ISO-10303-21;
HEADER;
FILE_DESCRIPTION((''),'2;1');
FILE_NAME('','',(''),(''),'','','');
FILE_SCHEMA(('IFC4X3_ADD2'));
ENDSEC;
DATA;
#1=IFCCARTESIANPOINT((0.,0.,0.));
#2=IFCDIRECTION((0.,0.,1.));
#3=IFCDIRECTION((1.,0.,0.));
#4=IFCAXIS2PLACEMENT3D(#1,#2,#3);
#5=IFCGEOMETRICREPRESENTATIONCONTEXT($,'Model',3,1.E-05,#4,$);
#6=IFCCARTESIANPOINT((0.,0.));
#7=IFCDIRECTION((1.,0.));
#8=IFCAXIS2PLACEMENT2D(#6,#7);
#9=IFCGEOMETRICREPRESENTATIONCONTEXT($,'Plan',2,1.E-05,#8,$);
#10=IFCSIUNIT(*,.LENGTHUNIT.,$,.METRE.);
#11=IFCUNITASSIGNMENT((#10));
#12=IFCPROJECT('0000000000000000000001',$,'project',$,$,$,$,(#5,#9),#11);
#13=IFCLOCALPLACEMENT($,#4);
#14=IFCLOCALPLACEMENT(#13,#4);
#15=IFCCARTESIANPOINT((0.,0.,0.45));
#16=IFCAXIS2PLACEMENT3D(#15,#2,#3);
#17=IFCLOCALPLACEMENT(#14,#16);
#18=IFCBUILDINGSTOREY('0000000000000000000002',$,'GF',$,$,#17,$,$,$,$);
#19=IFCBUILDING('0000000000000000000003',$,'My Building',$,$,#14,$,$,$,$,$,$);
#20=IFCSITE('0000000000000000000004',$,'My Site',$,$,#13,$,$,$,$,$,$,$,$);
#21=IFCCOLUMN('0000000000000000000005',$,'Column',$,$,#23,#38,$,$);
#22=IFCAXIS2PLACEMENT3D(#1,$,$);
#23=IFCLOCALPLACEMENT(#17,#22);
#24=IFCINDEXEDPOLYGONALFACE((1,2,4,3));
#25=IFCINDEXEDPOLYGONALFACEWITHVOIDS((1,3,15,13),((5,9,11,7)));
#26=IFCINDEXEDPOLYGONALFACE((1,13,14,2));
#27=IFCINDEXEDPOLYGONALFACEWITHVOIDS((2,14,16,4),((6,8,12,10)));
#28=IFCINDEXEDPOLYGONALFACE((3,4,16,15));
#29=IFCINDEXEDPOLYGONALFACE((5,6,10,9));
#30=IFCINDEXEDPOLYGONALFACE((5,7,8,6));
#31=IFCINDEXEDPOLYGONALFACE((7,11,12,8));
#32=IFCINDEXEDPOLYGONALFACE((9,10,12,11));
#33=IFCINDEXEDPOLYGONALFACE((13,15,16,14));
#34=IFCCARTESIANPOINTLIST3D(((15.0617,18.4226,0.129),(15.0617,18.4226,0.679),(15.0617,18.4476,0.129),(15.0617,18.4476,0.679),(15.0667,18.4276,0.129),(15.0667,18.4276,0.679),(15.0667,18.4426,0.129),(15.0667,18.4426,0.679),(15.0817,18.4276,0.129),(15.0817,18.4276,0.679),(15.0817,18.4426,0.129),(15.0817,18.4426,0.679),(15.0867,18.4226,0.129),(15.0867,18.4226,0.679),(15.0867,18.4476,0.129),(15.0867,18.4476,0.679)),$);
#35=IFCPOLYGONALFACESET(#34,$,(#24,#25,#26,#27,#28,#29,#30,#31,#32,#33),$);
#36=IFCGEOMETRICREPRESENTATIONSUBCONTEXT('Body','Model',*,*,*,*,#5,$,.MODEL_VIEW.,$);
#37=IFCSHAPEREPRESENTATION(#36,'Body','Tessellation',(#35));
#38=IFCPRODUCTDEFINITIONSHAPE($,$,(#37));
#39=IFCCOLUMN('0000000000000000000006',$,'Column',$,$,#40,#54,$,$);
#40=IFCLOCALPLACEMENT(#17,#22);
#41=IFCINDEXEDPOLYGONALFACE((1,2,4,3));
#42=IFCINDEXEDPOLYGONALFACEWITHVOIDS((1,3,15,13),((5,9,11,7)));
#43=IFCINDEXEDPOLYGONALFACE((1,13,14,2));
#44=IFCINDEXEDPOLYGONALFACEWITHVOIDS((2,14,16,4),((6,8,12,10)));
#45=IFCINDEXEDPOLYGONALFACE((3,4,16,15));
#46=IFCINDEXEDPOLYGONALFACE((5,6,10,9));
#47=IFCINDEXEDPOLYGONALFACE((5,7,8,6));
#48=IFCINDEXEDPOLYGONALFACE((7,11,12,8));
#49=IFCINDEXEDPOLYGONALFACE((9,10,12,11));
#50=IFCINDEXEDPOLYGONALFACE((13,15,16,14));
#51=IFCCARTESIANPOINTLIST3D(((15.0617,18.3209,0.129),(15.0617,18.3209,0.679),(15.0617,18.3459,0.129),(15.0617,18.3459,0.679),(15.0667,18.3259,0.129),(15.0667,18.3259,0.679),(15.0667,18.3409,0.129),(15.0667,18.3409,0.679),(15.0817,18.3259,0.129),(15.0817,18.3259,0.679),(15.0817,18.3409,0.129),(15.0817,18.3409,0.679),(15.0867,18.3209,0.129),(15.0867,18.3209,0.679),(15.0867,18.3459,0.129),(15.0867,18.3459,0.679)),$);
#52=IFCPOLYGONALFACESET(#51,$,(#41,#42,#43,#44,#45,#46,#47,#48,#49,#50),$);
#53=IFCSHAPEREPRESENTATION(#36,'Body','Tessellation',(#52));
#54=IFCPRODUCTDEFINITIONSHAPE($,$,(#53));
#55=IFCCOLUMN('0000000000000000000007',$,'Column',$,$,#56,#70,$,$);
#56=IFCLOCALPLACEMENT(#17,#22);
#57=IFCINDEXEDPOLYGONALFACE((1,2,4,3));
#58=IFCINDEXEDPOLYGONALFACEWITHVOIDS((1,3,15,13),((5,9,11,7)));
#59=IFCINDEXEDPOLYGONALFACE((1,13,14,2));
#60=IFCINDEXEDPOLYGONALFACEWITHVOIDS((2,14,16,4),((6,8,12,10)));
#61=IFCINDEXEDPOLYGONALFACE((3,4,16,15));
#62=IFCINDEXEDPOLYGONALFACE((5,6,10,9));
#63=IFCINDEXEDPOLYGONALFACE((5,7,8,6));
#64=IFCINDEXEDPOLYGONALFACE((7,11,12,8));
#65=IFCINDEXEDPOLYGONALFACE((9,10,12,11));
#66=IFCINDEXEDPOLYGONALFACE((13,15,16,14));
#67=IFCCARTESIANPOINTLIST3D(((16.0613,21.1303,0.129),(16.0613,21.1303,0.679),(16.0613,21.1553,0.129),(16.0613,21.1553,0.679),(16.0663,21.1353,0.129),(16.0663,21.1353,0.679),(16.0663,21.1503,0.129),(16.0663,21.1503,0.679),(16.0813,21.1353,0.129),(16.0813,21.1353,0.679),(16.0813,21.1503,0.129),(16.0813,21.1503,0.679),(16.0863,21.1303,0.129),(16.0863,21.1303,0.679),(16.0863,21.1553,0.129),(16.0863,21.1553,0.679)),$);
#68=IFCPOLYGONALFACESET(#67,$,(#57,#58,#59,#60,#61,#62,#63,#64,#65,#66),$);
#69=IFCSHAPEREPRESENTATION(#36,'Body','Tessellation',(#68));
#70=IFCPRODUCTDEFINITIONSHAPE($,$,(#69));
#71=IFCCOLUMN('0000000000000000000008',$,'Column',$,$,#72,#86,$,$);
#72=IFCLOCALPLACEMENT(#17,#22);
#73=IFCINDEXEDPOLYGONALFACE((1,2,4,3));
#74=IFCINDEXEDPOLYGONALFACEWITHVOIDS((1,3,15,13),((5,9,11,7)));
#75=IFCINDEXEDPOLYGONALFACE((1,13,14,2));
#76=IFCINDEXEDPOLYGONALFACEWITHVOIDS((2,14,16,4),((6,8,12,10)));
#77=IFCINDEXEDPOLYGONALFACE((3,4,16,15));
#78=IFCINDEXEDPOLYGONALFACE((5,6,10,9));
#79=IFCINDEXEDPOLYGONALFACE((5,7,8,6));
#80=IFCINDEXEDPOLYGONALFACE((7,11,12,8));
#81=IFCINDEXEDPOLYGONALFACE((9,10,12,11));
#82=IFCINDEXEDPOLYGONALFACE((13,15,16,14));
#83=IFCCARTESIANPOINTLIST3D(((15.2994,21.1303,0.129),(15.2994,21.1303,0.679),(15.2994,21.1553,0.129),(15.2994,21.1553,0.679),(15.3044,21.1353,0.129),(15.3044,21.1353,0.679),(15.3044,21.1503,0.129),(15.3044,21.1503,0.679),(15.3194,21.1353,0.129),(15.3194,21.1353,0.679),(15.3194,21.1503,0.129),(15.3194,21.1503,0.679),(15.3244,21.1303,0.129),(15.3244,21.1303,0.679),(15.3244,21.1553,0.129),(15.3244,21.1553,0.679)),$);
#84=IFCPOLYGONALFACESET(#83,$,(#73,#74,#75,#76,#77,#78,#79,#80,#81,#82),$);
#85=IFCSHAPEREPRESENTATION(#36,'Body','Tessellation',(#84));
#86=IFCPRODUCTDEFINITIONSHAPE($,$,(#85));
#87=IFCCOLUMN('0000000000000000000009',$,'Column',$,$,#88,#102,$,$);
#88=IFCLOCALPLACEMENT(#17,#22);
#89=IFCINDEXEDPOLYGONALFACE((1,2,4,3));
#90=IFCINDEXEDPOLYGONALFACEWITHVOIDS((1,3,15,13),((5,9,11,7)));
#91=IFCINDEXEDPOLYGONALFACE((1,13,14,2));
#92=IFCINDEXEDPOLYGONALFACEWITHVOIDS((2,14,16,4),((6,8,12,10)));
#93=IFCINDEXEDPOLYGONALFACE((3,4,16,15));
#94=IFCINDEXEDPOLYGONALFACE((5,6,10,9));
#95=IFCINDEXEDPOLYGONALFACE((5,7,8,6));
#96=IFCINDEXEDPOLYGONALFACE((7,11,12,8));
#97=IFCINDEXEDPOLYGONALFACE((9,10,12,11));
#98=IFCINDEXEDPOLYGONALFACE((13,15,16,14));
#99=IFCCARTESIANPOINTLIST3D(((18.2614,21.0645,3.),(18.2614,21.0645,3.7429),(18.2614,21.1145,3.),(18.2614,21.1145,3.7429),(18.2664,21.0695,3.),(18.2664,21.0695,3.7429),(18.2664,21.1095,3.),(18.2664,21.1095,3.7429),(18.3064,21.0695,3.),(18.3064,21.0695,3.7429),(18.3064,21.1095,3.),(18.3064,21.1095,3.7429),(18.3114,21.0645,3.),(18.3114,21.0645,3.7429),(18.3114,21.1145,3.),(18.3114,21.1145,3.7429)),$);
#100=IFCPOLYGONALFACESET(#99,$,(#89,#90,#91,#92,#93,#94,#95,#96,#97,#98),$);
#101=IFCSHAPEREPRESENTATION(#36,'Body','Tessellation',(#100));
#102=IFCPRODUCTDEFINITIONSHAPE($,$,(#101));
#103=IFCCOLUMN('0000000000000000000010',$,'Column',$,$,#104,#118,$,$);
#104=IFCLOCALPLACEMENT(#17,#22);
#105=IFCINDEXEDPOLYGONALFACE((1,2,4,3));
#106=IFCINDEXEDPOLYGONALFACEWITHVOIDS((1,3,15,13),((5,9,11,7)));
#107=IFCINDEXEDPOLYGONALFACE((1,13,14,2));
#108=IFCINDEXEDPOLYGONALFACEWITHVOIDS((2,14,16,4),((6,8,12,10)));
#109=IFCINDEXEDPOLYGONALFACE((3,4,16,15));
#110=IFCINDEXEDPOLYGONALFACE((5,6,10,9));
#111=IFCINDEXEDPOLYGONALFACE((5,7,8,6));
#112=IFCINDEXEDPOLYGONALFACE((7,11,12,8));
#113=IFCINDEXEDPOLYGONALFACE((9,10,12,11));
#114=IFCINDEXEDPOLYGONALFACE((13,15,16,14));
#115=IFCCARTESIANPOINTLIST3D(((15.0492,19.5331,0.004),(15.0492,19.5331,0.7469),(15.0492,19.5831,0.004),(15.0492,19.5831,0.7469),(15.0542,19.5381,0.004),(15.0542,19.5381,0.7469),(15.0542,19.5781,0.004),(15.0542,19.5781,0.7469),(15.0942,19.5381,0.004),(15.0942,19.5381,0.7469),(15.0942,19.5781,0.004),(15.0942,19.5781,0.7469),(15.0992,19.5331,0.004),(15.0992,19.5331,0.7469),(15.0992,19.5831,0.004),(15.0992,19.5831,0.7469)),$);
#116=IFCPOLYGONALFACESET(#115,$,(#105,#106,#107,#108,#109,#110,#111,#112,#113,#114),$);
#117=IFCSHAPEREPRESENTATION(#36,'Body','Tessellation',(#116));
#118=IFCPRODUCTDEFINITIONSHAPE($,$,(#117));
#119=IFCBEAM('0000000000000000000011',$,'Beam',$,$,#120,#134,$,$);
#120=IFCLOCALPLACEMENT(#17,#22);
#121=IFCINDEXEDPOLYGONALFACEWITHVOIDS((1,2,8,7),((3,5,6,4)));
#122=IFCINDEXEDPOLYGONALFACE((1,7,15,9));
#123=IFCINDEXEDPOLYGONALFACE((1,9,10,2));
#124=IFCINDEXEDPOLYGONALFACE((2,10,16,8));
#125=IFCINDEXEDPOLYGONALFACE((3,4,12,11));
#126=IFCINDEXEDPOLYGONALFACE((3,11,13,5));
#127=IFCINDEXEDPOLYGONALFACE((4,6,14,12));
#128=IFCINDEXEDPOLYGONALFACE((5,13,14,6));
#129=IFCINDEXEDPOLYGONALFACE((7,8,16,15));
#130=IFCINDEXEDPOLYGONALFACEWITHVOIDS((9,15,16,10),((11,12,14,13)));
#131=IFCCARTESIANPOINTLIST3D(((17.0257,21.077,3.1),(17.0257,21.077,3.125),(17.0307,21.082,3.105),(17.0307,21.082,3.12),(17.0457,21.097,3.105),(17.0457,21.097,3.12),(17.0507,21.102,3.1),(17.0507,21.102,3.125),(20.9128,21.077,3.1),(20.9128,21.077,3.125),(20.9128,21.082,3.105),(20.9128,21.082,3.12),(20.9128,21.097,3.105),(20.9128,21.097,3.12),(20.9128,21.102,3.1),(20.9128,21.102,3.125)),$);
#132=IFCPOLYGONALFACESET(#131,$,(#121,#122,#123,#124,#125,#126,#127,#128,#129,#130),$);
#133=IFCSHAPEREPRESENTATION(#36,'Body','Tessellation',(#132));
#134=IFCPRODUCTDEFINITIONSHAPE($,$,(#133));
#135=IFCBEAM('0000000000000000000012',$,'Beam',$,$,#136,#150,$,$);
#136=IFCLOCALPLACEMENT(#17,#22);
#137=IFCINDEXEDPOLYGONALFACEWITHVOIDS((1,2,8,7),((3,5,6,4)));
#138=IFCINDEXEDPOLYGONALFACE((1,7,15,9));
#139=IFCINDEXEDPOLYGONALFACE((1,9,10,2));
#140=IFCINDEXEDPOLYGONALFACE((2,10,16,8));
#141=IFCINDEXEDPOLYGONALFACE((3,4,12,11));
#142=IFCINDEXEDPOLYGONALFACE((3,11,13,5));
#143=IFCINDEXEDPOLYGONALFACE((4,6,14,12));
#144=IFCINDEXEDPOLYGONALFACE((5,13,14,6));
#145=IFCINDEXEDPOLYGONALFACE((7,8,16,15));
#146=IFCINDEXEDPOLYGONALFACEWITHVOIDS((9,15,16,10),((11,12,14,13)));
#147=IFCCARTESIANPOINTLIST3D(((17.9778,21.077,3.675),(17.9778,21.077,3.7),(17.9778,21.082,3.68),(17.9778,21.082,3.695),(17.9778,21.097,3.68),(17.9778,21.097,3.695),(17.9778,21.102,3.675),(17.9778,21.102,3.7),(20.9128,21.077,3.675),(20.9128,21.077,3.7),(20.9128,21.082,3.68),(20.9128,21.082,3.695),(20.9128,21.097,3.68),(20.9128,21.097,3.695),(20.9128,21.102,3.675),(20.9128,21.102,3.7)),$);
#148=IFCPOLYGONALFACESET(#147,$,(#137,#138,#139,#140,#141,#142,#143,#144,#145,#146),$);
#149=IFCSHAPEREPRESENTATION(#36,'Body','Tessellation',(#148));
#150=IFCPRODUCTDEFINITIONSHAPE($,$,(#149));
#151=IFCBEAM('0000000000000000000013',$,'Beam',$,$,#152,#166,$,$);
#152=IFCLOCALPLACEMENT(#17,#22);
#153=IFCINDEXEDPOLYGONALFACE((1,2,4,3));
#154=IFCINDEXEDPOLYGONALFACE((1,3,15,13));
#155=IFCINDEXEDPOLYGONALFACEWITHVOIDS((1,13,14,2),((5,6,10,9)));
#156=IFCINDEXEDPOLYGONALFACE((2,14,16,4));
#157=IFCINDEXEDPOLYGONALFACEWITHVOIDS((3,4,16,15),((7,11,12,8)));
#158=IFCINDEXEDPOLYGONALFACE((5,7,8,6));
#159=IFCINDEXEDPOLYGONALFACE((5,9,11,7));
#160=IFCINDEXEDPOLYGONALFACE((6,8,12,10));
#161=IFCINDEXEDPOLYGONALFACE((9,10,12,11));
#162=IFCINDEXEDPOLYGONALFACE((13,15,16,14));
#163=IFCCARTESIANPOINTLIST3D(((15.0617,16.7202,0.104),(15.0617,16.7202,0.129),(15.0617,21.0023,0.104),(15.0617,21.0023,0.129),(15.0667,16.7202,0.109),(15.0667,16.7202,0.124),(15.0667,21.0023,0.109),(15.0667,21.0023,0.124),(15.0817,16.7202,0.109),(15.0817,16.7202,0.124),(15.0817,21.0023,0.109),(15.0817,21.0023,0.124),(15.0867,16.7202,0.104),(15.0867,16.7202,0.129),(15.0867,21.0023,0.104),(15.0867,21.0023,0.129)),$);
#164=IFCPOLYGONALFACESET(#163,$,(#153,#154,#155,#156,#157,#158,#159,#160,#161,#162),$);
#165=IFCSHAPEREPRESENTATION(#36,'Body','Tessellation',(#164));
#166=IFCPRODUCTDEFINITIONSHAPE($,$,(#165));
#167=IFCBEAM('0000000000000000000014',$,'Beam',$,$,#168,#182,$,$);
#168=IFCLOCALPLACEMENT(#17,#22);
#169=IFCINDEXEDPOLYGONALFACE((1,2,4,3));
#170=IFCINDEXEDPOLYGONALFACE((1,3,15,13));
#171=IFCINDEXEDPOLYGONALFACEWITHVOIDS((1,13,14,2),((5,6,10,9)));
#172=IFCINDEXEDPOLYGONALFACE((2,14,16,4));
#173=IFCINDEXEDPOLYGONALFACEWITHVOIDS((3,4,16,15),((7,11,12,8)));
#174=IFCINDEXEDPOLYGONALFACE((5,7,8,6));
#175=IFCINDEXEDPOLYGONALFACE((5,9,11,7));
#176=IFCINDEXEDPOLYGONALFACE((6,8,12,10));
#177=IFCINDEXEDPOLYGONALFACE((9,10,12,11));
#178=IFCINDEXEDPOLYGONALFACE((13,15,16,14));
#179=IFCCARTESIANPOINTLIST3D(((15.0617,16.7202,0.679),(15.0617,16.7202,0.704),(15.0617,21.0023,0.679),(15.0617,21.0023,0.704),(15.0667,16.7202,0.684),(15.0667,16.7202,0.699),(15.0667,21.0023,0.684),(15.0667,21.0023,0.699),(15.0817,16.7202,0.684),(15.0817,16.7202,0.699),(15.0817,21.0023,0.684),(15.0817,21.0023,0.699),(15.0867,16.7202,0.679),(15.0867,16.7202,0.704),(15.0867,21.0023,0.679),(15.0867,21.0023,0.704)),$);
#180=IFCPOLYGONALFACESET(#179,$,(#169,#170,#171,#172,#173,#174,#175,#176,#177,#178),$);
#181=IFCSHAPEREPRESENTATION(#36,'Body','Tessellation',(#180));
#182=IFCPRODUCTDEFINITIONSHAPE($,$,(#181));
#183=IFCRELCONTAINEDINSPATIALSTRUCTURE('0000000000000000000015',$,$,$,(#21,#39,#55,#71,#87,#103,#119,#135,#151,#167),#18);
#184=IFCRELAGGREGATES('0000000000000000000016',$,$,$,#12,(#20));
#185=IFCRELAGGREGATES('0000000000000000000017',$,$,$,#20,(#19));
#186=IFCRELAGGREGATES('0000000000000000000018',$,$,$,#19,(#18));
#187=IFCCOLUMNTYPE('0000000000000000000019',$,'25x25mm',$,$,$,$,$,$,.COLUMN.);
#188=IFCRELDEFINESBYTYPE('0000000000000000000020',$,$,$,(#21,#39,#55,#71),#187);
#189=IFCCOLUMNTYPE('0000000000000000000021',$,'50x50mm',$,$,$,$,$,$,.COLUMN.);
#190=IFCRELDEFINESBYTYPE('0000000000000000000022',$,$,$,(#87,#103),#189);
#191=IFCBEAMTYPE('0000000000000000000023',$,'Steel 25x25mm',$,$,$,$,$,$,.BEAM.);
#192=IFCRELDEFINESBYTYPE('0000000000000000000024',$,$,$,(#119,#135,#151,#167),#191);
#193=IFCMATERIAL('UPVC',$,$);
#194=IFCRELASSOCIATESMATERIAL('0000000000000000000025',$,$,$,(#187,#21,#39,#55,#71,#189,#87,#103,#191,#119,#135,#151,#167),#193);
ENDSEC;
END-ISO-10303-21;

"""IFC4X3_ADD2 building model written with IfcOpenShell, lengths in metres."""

from ifc_helpers import new_model, si_unit, frame, origin_with_axes, origin_2d_with_axis, place, context, subcontext, project, spatial, hollow_rectangle, extrude, clip, halfspace, material, material_profile, profile_set, profile_usage, type_object, element, save


model = new_model("IFC4X3_ADD2")

# Units and contexts
model_context = context("Model", 3, precision=1e-05, world=origin_with_axes())
plan_context = context("Plan", 2, precision=1e-05, world=origin_2d_with_axis())
body_context_1 = subcontext(model_context, "Body", "Model", "MODEL_VIEW")
ifc_project = project(units=[si_unit("LENGTHUNIT", "METRE")], contexts=[model_context, plan_context])

# Site, building, storey
site_placement = place(None, origin_with_axes())
site = spatial("IfcSite", under=ifc_project, at=site_placement, Name="My Site")
building_placement = place(site_placement, origin_with_axes())
building = spatial("IfcBuilding", under=site, at=building_placement, Name="My Building")
storey_placement = place(building_placement, frame((0.0, 0.0, 0.45), z_axis=(0.0, 0.0, 1.0), x_axis=(1.0, 0.0, 0.0)))
storey = spatial("IfcBuildingStorey", under=building, at=storey_placement, Name="GF")

# Columns
ifc_material_1 = material(Name="UPVC")
ifc_material_profile_1 = material_profile(ifc_material_1, hollow_rectangle(XDim=0.025, YDim=0.025, WallThickness=0.005))
ifc_profile_set_1 = profile_set([ifc_material_profile_1])
column_type_1 = type_object("IfcColumnType", Name="25x25mm", PredefinedType="COLUMN", material=ifc_profile_set_1)
ifc_profile_usage_1 = profile_usage(ifc_profile_set_1)
column_1_placement = place(storey_placement, frame((15.0742, 18.4351, 0.129), z_axis=(0.0, 0.0, 1.0), x_axis=(0.0, -1.0, 0.0)))
element("IfcColumn", 1, at=column_1_placement, inside=storey, type_object=column_type_1, material=ifc_profile_usage_1, Name="Column", context=body_context_1, shape_type="SweptSolid", body=[
    extrude(hollow_rectangle(XDim=0.025, YDim=0.025, WallThickness=0.005), origin_with_axes(), (0.0, 0.0, 1.0), 0.55),
])
ifc_profile_usage_2 = profile_usage(ifc_profile_set_1)
column_2_placement = place(storey_placement, frame((15.0742, 18.3334, 0.129), z_axis=(0.0, 0.0, 1.0), x_axis=(0.0, -1.0, 0.0)))
element("IfcColumn", 2, at=column_2_placement, inside=storey, type_object=column_type_1, material=ifc_profile_usage_2, Name="Column", context=body_context_1, shape_type="SweptSolid", body=[
    extrude(hollow_rectangle(XDim=0.025, YDim=0.025, WallThickness=0.005), origin_with_axes(), (0.0, 0.0, 1.0), 0.55),
])
ifc_profile_usage_3 = profile_usage(ifc_profile_set_1)
column_3_placement = place(storey_placement, frame((16.0738, 21.1428, 0.129), z_axis=(0.0, 0.0, 1.0), x_axis=(0.0, -1.0, 0.0)))
element("IfcColumn", 3, at=column_3_placement, inside=storey, type_object=column_type_1, material=ifc_profile_usage_3, Name="Column", context=body_context_1, shape_type="SweptSolid", body=[
    extrude(hollow_rectangle(XDim=0.025, YDim=0.025, WallThickness=0.005), origin_with_axes(), (0.0, 0.0, 1.0), 0.55),
])
ifc_profile_usage_4 = profile_usage(ifc_profile_set_1)
column_4_placement = place(storey_placement, frame((15.3119, 21.1428, 0.129), z_axis=(0.0, 0.0, 1.0), x_axis=(0.0, -1.0, 0.0)))
element("IfcColumn", 4, at=column_4_placement, inside=storey, type_object=column_type_1, material=ifc_profile_usage_4, Name="Column", context=body_context_1, shape_type="SweptSolid", body=[
    extrude(hollow_rectangle(XDim=0.025, YDim=0.025, WallThickness=0.005), origin_with_axes(), (0.0, 0.0, 1.0), 0.55),
])
ifc_material_profile_2 = material_profile(ifc_material_1, hollow_rectangle(XDim=0.05, YDim=0.05, WallThickness=0.005))
ifc_profile_set_2 = profile_set([ifc_material_profile_2])
ifc_profile_usage_5 = profile_usage(ifc_profile_set_2)
column_type_2 = type_object("IfcColumnType", Name="50x50mm", PredefinedType="COLUMN", material=ifc_profile_set_2)
column_5_placement = place(storey_placement, frame((18.2864, 21.0895, 3.0), z_axis=(0.0, 0.0, 1.0), x_axis=(1.0, 0.0, 0.0)))
element("IfcColumn", 5, at=column_5_placement, inside=storey, type_object=column_type_2, material=ifc_profile_usage_5, Name="Column", context=body_context_1, shape_type="SweptSolid", body=[
    extrude(hollow_rectangle(XDim=0.05, YDim=0.05, WallThickness=0.005), origin_with_axes(), (0.0, 0.0, 1.0), 0.7429),
])
ifc_profile_usage_6 = profile_usage(ifc_profile_set_2)
column_6_placement = place(storey_placement, frame((15.0742, 19.5581, 0.004), z_axis=(0.0, 0.0, 1.0), x_axis=(0.0, -1.0, 0.0)))
element("IfcColumn", 6, at=column_6_placement, inside=storey, type_object=column_type_2, material=ifc_profile_usage_6, Name="Column", context=body_context_1, shape_type="SweptSolid", body=[
    extrude(hollow_rectangle(XDim=0.05, YDim=0.05, WallThickness=0.005), origin_with_axes(), (0.0, 0.0, 1.0), 0.7429),
])

# Beams
ifc_material_profile_3 = material_profile(ifc_material_1, hollow_rectangle(XDim=0.025, YDim=0.025, WallThickness=0.005))
ifc_profile_set_3 = profile_set([ifc_material_profile_3])
ifc_profile_usage_7 = profile_usage(ifc_profile_set_3)
beam_type_1 = type_object("IfcBeamType", Name="Steel 25x25mm", PredefinedType="BEAM", material=ifc_profile_set_3)
beam_1_placement = place(storey_placement, frame((17.0257, 21.0895, 3.1125), z_axis=(1.0, 0.0, 0.0), x_axis=(0.0, 1.0, 0.0)))
element("IfcBeam", 7, at=beam_1_placement, inside=storey, type_object=beam_type_1, material=ifc_profile_usage_7, Name="Beam", context=body_context_1, shape_type="Clipping", body=[
    clip(extrude(hollow_rectangle(XDim=0.025, YDim=0.025, WallThickness=0.005), origin_with_axes(), (0.0, 0.0, 1.0), 3.8871), halfspace(frame((-0.0125, -3.5625, 0.0), z_axis=(0.707134, 0.0, -0.70708), x_axis=(0.0, -1.0, 0.0)), False)),
])
ifc_profile_usage_8 = profile_usage(ifc_profile_set_3)
beam_2_placement = place(storey_placement, frame((17.9778, 21.0895, 3.6875), z_axis=(1.0, 0.0, 0.0), x_axis=(0.0, 1.0, 0.0)))
element("IfcBeam", 8, at=beam_2_placement, inside=storey, type_object=beam_type_1, material=ifc_profile_usage_8, Name="Beam", context=body_context_1, shape_type="SweptSolid", body=[
    extrude(hollow_rectangle(XDim=0.025, YDim=0.025, WallThickness=0.005), origin_with_axes(), (0.0, 0.0, 1.0), 2.9351),
])
ifc_profile_usage_9 = profile_usage(ifc_profile_set_3)
beam_3_placement = place(storey_placement, frame((15.0742, 21.0023, 0.1165), z_axis=(0.0, -1.0, 0.0), x_axis=(1.0, 0.0, 0.0)))
element("IfcBeam", 9, at=beam_3_placement, inside=storey, type_object=beam_type_1, material=ifc_profile_usage_9, Name="Beam", context=body_context_1, shape_type="SweptSolid", body=[
    extrude(hollow_rectangle(XDim=0.025, YDim=0.025, WallThickness=0.005), origin_with_axes(), (0.0, 0.0, 1.0), 4.2821),
])
ifc_profile_usage_10 = profile_usage(ifc_profile_set_3)
beam_4_placement = place(storey_placement, frame((15.0742, 21.0023, 0.6915), z_axis=(0.0, -1.0, 0.0), x_axis=(1.0, 0.0, 0.0)))
element("IfcBeam", 10, at=beam_4_placement, inside=storey, type_object=beam_type_1, material=ifc_profile_usage_10, Name="Beam", context=body_context_1, shape_type="SweptSolid", body=[
    extrude(hollow_rectangle(XDim=0.025, YDim=0.025, WallThickness=0.005), origin_with_axes(), (0.0, 0.0, 1.0), 4.2821),
])

save(model, "model.ifc")
